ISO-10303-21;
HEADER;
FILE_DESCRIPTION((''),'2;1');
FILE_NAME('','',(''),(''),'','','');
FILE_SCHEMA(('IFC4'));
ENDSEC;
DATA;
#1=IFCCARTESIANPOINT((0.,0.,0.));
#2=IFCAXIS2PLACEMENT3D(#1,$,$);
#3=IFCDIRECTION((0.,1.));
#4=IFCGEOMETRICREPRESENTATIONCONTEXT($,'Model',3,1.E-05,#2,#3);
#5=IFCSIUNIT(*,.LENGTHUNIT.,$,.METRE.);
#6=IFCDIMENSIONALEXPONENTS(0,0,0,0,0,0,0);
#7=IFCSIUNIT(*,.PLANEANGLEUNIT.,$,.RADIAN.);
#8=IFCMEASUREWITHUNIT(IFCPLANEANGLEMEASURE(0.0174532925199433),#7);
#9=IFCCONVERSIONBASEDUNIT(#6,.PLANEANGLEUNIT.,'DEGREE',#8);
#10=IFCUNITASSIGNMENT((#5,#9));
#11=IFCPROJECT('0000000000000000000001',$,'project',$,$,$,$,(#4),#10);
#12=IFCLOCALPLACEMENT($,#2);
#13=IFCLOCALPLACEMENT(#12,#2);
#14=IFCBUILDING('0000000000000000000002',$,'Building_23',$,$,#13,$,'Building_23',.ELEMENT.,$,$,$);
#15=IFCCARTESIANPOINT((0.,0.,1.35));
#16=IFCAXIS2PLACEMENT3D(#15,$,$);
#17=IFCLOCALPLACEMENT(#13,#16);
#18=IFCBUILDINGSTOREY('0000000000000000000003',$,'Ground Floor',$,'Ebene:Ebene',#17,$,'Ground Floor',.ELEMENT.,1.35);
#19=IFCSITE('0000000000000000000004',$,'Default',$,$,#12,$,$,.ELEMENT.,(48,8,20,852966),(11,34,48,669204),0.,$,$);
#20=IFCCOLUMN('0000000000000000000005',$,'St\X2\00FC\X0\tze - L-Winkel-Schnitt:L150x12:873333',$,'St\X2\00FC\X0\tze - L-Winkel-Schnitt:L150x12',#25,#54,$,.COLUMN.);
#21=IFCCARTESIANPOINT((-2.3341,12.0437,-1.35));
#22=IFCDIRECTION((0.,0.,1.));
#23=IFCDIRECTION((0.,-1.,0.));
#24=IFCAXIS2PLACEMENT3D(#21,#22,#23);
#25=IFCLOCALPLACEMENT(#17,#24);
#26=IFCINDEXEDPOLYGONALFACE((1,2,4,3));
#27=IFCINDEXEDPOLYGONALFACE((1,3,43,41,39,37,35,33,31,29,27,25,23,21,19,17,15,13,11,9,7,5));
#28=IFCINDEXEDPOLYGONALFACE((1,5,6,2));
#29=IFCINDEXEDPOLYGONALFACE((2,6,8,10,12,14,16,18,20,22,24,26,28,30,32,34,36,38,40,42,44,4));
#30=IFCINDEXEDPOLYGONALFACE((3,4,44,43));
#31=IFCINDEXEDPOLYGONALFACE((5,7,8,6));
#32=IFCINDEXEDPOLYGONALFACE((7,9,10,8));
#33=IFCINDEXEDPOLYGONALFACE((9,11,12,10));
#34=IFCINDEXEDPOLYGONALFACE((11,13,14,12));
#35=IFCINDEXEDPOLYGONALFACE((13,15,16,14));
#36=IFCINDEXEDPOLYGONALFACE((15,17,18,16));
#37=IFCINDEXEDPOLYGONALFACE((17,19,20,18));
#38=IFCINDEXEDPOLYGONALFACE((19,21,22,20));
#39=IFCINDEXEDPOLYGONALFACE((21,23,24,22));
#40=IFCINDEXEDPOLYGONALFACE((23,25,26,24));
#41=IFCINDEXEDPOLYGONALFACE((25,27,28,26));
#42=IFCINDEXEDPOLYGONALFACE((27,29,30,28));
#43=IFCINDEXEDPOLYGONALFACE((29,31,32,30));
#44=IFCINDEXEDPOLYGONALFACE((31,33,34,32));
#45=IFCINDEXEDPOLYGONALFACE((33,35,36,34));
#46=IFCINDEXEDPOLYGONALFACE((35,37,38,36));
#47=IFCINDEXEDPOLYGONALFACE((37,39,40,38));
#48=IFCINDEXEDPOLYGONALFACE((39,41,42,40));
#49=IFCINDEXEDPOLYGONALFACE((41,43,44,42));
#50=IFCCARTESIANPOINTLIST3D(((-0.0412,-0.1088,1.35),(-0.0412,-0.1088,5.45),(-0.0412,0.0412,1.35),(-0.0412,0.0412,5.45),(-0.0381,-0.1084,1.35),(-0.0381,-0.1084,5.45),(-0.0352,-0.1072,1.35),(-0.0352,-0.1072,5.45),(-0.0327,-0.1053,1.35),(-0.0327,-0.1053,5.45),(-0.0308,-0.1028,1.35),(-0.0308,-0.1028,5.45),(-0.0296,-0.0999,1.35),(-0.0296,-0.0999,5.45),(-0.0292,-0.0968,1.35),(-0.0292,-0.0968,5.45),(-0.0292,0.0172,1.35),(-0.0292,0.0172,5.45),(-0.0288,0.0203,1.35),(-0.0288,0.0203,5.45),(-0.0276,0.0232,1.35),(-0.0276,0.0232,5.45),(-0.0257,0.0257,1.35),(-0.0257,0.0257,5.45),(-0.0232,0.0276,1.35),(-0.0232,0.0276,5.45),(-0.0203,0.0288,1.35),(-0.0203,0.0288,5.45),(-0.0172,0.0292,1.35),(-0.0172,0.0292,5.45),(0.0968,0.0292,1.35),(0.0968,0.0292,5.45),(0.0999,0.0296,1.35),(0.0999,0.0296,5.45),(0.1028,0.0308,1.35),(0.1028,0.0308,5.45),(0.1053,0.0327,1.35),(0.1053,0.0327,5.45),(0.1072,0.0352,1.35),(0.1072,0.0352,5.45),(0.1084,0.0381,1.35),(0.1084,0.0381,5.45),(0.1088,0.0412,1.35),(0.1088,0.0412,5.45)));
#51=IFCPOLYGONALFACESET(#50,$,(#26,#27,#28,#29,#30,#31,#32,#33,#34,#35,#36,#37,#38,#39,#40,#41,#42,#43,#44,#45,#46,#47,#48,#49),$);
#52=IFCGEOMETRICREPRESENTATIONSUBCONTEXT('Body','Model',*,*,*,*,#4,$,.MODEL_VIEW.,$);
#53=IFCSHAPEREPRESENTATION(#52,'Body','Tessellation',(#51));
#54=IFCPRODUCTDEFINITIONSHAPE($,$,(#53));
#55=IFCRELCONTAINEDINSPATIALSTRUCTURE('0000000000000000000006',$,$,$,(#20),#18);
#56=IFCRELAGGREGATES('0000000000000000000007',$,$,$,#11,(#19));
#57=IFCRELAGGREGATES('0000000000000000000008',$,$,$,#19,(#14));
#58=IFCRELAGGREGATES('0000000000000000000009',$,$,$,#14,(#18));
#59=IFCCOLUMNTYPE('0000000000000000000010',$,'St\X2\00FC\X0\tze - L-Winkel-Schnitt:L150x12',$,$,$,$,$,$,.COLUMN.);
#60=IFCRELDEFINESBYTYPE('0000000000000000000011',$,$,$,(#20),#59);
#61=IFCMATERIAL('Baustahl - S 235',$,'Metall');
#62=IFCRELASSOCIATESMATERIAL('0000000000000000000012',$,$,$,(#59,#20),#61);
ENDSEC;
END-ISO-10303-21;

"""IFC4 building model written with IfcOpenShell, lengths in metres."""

from ifc_helpers import new_model, entity, si_unit, converted_unit, direction, frame, origin, place, context, subcontext, project, spatial, line, arc, indexed_curve, outline, extrude, source, transform, mapped, material, type_object, type_shapes, element, save


model = new_model("IFC4")

# Units and contexts
model_context = context("Model", 3, precision=1e-05, world=origin(), true_north=direction((0.0, 1.0)))
body_context = subcontext(model_context, "Body", "Model", "MODEL_VIEW")
ifc_project = project(units=[si_unit("LENGTHUNIT", "METRE"), converted_unit("PLANEANGLEUNIT", "DEGREE", entity("IfcPlaneAngleMeasure", 0.0174532925199433), si_unit("PLANEANGLEUNIT", "RADIAN"), dimensions=[0, 0, 0, 0, 0, 0, 0])], contexts=[model_context])

# Site, building, storey
site_placement = place(None, origin())
site = spatial("IfcSite", under=ifc_project, at=site_placement, Name="Default", CompositionType="ELEMENT", RefLatitude=(48, 8, 20, 852966), RefLongitude=(11, 34, 48, 669204), RefElevation=0.0)
building_placement = place(site_placement, origin())
building = spatial("IfcBuilding", under=site, at=building_placement, Name="Building_23", LongName="Building_23", CompositionType="ELEMENT")
storey_placement = place(building_placement, frame((0.0, 0.0, 1.35)))
storey = spatial("IfcBuildingStorey", under=building, at=storey_placement, Name="Ground Floor", ObjectType="Ebene:Ebene", LongName="Ground Floor", CompositionType="ELEMENT", Elevation=1.35)

# Column
ifc_material_1 = material(Name="Baustahl - S 235", Category="Metall")
column_type_1 = type_object("IfcColumnType", Name="Stütze - L-Winkel-Schnitt:L150x12", PredefinedType="COLUMN", material=ifc_material_1)
shared_shape_1 = source(origin(), body_context, "Body", "SweptSolid", [
    extrude(outline(indexed_curve([(-0.102, -0.048), (0.048, -0.048), (0.048, 0.102), (0.0395, 0.0985), (0.036, 0.09), (0.036, -0.024), (0.0325, -0.0325), (0.024, -0.036), (-0.09, -0.036), (-0.0985, -0.0395)], segments=[line(1, 2, 3), arc(3, 4, 5), line(5, 6), arc(6, 7, 8), line(8, 9), arc(9, 10, 1)], self_intersect=False)), frame((0.0068, -0.0068, 1.35), z_axis=(0.0, 0.0, 1.0), x_axis=(-1.0, 0.0, 0.0)), (0.0, 0.0, 1.0), 4.1),
])
type_shapes(column_type_1, [shared_shape_1])
column_1_placement = place(storey_placement, frame((-2.3341, 12.0437, -1.35), z_axis=(0.0, 0.0, 1.0), x_axis=(0.0, -1.0, 0.0)))
element("IfcColumn", 1, at=column_1_placement, inside=storey, type_object=column_type_1, material=ifc_material_1, Name="Stütze - L-Winkel-Schnitt:L150x12:873333", ObjectType="Stütze - L-Winkel-Schnitt:L150x12", PredefinedType="COLUMN", context=body_context, shape_type="MappedRepresentation", body=[
    mapped(shared_shape_1, transform((0.0, 0.0, 0.0), scale=1.0)),
])

save(model, "model.ifc")
